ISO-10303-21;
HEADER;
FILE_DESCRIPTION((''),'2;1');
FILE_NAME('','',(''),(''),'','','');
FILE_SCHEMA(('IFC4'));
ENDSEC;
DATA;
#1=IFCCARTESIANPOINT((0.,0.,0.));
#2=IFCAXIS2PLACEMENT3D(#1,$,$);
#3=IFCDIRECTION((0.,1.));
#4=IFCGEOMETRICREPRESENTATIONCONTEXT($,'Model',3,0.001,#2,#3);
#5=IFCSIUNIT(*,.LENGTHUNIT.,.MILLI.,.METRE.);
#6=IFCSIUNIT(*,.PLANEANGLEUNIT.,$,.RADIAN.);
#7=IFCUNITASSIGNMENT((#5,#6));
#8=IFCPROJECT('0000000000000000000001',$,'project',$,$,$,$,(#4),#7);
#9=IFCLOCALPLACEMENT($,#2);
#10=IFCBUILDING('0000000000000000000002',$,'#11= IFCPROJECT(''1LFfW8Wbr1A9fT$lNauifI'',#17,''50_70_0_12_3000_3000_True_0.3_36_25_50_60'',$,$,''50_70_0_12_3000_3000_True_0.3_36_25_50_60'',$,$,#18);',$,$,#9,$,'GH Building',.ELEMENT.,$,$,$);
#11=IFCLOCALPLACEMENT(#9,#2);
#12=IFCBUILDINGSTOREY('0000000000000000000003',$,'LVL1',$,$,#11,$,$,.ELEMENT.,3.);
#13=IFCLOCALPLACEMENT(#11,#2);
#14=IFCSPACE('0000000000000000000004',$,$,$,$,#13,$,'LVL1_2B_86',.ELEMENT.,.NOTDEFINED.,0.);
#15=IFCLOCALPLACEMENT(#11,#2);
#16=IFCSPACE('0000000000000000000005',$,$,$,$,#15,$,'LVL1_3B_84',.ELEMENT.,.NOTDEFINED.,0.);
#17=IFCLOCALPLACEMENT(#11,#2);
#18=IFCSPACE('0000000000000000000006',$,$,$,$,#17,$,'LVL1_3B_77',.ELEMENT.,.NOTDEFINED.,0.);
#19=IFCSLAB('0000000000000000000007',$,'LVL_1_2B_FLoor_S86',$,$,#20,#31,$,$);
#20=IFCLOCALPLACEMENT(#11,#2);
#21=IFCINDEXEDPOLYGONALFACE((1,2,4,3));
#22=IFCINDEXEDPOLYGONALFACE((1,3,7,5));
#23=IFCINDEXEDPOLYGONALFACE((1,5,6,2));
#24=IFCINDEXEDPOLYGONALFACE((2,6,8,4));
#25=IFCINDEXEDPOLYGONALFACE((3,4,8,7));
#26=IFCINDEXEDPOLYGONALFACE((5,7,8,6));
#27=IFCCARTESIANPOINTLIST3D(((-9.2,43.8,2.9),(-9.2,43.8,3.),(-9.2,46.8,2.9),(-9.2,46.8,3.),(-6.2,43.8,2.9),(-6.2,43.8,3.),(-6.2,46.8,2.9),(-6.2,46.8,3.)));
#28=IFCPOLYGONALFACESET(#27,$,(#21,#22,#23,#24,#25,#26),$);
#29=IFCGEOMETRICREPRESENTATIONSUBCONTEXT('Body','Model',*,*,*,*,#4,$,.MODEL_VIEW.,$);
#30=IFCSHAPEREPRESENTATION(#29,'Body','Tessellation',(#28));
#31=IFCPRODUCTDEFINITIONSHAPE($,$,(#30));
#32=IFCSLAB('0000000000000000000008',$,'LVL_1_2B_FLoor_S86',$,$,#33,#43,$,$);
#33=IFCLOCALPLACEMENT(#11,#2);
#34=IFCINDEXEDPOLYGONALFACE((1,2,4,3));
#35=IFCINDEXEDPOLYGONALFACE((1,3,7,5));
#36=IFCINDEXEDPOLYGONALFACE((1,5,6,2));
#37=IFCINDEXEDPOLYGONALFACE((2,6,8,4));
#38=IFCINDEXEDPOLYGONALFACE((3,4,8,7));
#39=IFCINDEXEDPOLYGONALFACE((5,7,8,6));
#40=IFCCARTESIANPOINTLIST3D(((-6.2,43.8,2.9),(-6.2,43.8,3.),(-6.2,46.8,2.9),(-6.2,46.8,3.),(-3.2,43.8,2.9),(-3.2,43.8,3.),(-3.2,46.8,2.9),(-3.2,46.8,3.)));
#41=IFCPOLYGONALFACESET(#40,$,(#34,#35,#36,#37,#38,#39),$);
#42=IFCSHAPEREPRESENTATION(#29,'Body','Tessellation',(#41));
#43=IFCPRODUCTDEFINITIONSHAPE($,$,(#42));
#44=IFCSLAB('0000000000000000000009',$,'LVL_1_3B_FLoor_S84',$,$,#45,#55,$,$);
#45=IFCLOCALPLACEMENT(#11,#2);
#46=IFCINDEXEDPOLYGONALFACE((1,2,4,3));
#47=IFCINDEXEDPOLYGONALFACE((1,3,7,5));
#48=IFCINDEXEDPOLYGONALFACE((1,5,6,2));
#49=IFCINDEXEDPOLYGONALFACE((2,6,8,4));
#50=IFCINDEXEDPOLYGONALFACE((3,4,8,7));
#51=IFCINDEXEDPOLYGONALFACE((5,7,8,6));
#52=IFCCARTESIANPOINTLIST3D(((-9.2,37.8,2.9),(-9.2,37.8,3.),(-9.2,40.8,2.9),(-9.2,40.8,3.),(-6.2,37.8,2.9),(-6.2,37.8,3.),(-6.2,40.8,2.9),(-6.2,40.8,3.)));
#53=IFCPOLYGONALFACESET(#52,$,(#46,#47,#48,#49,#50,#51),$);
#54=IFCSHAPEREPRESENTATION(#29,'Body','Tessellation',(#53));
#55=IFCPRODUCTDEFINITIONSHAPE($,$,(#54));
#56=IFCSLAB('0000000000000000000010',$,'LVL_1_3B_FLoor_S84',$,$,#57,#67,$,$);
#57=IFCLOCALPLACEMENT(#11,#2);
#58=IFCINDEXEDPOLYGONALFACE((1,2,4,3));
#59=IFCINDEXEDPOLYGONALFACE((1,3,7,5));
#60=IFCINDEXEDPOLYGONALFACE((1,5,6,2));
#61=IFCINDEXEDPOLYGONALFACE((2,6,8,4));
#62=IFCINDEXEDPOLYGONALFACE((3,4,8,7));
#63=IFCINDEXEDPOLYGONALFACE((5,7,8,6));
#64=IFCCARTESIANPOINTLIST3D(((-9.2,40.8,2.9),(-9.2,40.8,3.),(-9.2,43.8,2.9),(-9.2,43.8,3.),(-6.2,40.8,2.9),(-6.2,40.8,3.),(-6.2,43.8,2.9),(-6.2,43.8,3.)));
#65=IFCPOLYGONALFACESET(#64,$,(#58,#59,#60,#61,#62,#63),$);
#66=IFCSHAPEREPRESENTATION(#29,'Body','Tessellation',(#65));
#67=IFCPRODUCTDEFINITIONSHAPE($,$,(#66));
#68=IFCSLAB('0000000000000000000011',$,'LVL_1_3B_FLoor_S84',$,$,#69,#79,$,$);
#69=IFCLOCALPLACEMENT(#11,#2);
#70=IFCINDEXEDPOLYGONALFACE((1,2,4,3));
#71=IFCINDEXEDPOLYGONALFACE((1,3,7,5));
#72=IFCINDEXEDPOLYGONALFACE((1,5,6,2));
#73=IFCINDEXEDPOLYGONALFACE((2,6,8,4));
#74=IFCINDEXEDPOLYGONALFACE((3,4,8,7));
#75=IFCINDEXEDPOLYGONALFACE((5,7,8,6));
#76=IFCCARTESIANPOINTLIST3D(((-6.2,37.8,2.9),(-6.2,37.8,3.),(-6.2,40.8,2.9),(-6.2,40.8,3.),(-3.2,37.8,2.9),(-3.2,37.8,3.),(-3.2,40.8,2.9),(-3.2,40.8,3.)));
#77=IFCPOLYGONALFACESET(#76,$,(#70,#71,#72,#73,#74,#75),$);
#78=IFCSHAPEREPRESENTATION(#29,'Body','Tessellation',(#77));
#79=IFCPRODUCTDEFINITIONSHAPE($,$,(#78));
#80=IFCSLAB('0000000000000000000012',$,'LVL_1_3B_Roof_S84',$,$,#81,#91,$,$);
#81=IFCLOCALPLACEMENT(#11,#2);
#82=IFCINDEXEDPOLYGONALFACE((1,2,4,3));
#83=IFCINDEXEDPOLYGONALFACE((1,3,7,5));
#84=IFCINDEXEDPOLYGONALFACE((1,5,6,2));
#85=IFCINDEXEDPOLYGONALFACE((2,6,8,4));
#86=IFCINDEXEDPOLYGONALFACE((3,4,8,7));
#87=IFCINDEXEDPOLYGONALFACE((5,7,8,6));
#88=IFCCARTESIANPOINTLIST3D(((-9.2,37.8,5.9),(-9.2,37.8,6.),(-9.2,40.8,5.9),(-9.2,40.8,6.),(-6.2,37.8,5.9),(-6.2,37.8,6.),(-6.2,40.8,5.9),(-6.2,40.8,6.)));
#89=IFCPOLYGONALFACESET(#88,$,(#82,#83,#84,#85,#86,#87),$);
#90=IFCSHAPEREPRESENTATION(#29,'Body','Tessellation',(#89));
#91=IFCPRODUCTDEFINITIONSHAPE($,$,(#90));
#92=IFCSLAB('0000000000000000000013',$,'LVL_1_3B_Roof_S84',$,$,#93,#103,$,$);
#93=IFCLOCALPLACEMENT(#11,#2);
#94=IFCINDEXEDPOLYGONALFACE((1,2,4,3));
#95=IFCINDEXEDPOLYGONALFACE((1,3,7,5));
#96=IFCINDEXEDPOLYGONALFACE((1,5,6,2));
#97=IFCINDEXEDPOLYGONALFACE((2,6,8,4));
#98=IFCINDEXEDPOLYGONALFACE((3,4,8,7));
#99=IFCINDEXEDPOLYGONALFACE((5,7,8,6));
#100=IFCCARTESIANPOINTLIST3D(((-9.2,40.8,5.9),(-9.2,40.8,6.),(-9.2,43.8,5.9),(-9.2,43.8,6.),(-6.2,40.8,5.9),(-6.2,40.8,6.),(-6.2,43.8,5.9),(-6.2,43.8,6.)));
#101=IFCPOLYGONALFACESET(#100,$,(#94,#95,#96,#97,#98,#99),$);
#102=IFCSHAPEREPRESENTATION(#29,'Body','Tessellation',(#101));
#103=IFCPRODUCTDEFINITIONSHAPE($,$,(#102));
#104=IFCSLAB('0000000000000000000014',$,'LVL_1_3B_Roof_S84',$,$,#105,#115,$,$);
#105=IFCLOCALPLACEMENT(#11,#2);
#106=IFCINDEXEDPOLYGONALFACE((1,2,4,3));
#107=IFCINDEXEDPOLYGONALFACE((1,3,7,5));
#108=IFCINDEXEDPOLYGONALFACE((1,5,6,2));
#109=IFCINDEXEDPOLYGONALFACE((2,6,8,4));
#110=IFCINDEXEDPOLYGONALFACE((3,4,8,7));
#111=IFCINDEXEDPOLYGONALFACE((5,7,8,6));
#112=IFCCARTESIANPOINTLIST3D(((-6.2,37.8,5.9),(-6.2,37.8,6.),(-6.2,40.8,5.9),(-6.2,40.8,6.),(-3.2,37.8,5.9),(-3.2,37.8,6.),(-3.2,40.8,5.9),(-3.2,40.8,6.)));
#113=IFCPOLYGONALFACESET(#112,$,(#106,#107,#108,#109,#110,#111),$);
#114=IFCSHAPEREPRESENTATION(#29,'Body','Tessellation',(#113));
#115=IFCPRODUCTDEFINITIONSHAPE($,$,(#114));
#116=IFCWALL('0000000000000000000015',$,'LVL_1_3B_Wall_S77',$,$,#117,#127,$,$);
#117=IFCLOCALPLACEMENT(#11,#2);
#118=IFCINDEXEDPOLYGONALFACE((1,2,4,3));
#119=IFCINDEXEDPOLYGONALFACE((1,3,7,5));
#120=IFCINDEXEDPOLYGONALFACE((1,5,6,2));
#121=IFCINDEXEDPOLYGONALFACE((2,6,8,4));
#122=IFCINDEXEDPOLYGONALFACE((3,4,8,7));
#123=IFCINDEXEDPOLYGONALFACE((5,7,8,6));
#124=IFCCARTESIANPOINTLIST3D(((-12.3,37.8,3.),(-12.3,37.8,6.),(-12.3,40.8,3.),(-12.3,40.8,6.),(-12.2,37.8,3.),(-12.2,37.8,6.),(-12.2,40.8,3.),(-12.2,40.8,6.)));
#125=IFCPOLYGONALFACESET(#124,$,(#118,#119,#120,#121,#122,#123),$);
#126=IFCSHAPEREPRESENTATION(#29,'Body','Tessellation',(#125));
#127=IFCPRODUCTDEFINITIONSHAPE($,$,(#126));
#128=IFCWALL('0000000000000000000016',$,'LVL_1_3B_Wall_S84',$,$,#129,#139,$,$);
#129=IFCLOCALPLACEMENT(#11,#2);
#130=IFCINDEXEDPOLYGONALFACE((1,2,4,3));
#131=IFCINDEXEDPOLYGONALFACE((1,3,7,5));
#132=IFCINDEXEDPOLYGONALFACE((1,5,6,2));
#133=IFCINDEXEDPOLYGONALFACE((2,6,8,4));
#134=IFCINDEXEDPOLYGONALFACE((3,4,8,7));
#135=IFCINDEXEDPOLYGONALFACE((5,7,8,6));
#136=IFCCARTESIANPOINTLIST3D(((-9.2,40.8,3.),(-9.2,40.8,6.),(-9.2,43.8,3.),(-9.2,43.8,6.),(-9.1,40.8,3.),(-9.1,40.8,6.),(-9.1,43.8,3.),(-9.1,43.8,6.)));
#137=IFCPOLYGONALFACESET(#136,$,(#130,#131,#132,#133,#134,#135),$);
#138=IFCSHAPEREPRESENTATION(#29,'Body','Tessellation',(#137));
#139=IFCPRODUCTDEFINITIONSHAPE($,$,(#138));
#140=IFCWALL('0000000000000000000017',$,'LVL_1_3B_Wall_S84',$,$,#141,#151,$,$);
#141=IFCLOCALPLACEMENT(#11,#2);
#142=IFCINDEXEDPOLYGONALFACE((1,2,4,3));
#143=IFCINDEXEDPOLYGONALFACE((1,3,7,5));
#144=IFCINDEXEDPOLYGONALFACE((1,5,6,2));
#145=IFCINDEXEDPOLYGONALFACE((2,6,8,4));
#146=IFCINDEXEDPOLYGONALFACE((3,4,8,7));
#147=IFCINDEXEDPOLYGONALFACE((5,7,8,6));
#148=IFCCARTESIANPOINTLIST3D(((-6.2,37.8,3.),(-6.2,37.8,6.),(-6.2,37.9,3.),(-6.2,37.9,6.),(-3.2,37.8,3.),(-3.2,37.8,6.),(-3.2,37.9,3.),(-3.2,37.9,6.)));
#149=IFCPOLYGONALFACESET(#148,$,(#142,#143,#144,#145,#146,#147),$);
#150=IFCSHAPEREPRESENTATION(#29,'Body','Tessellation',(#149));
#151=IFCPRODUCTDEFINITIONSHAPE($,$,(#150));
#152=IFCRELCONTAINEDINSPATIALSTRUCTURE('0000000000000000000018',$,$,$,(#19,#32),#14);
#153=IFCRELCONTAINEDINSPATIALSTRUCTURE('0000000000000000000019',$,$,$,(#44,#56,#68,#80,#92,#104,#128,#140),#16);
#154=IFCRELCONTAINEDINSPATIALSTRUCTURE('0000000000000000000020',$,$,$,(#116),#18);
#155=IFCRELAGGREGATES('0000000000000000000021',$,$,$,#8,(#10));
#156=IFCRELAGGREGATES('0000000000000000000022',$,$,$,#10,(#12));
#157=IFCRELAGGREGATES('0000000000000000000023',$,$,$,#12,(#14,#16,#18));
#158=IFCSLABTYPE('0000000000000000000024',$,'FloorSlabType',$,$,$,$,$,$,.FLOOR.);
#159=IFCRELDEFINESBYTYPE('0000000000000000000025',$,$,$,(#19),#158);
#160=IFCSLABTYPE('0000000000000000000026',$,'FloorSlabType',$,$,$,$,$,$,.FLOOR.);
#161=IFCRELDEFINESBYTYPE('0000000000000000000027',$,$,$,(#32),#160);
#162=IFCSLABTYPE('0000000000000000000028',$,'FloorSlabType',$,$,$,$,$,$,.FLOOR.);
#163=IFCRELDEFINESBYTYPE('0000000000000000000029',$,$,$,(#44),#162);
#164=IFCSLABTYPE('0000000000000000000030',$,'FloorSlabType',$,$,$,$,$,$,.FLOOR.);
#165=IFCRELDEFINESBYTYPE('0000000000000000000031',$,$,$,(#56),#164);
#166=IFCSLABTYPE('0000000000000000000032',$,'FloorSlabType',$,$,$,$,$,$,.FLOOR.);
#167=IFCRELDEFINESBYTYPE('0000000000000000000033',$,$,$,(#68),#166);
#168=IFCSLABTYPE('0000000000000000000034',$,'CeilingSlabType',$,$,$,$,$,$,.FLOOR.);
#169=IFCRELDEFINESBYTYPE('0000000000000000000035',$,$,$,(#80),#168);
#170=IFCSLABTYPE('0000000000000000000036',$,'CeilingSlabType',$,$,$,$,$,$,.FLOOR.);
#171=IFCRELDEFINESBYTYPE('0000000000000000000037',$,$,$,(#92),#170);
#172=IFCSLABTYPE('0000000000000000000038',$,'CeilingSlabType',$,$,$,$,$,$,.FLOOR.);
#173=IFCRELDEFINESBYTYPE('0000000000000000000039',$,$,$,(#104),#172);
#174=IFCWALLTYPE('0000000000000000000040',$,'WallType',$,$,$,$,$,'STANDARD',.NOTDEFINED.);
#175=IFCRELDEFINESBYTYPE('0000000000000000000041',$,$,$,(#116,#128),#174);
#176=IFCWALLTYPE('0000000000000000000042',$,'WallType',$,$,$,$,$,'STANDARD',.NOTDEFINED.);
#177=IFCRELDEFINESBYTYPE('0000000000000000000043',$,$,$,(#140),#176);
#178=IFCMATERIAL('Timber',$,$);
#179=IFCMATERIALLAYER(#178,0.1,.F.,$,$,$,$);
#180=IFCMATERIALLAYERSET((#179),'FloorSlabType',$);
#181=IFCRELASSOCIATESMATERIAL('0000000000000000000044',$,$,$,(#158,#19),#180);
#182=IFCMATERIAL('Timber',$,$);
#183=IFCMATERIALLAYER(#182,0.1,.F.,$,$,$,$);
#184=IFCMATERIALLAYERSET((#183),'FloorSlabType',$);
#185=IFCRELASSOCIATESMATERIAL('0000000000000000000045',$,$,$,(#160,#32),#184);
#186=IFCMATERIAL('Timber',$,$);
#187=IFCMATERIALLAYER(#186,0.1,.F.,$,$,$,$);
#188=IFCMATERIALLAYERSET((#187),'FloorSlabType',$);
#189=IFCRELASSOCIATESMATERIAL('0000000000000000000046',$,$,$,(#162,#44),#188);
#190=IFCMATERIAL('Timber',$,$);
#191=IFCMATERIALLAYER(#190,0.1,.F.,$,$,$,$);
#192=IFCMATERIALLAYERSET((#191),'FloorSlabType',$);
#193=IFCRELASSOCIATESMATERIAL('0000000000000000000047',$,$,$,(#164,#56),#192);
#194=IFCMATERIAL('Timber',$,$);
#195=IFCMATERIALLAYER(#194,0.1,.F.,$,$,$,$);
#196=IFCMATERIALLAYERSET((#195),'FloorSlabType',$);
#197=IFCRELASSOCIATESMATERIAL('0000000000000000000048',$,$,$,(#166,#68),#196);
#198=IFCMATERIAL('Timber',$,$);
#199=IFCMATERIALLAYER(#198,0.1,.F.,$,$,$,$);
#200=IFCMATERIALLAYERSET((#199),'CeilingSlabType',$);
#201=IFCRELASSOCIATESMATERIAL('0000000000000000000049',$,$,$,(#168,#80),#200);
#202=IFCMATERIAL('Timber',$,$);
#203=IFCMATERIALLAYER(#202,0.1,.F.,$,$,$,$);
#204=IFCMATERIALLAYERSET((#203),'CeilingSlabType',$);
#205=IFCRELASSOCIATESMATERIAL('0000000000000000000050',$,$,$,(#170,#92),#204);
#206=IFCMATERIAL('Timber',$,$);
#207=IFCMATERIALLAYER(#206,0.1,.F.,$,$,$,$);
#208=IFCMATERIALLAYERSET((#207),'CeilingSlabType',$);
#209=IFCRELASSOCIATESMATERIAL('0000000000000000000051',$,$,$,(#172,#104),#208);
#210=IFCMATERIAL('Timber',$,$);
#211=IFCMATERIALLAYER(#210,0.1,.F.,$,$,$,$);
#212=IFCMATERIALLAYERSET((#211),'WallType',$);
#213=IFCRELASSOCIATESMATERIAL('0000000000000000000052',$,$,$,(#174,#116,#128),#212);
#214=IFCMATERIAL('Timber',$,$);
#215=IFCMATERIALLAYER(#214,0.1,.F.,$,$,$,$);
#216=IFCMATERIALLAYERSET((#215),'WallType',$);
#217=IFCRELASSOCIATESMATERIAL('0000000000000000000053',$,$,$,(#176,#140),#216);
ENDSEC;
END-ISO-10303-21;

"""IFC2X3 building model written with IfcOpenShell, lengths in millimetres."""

from ifc_helpers import new_model, si_unit, direction, frame, frame_2d, origin, place, context, subcontext, project, spatial, rectangle, extrude, material, layer, layer_set, layer_usage, type_object, element, save


model = new_model("IFC2X3")

# Units and contexts
model_context = context("Model", 3, precision=0.001, world=origin(), true_north=direction((0.0, 1.0)))
body_context = subcontext(model_context, "Body", "Model", "MODEL_VIEW")
ifc_project = project(units=[si_unit("LENGTHUNIT", "METRE", prefix="MILLI"), si_unit("PLANEANGLEUNIT", "RADIAN")], contexts=[model_context])

# Building, storey
building_placement = place(None, origin())
building = spatial("IfcBuilding", under=ifc_project, at=building_placement, Name="#11= IFCPROJECT('1LFfW8Wbr1A9fT$lNauifI',#17,'50_70_0_12_3000_3000_True_0.3_36_25_50_60',$,$,'50_70_0_12_3000_3000_True_0.3_36_25_50_60',$,$,#18);", LongName="GH Building", CompositionType="ELEMENT")
storey_placement = place(building_placement, origin())
storey = spatial("IfcBuildingStorey", under=building, at=storey_placement, Name="LVL1", CompositionType="ELEMENT", Elevation=3.0)

# Shared definitions
space_1_placement = place(storey_placement, origin())
space_1 = spatial("IfcSpace", under=storey, at=space_1_placement, LongName="LVL1_2B_86", CompositionType="ELEMENT", InteriorOrExteriorSpace="NOTDEFINED", ElevationWithFlooring=0.0)

# Slabs
ifc_material_1 = material(Name="Timber")
ifc_layer_1 = layer(ifc_material_1, 0.1, ventilated=False)
ifc_layer_set_1 = layer_set([ifc_layer_1], Name="FloorSlabType")
ifc_layer_usage_1 = layer_usage(ifc_layer_set_1, "AXIS3", "NEGATIVE", -0.1)
slab_type_1 = type_object("IfcSlabType", Name="FloorSlabType", PredefinedType="FLOOR", material=ifc_layer_set_1)
slab_1_placement = place(space_1_placement, frame((-6.2, 43.8, 2.9), z_axis=(0.0, 0.0, 1.0), x_axis=(0.0, 1.0, 0.0)))
element("IfcSlab", 1, at=slab_1_placement, inside=space_1, type_object=slab_type_1, material=ifc_layer_usage_1, Name="LVL_1_2B_FLoor_S86", context=body_context, shape_type="SweptSolid", body=[
    extrude(rectangle(XDim=3.0, YDim=3.0, at=frame_2d((1.5, 1.5))), origin(), (0.0, 0.0, 1.0), 0.1),
])
ifc_material_2 = material(Name="Timber")
ifc_layer_2 = layer(ifc_material_2, 0.1, ventilated=False)
ifc_layer_set_2 = layer_set([ifc_layer_2], Name="FloorSlabType")
ifc_layer_usage_2 = layer_usage(ifc_layer_set_2, "AXIS3", "NEGATIVE", -0.1)
slab_type_2 = type_object("IfcSlabType", Name="FloorSlabType", PredefinedType="FLOOR", material=ifc_layer_set_2)
slab_2_placement = place(space_1_placement, frame((-3.2, 43.8, 2.9), z_axis=(0.0, 0.0, 1.0), x_axis=(0.0, 1.0, 0.0)))
element("IfcSlab", 2, at=slab_2_placement, inside=space_1, type_object=slab_type_2, material=ifc_layer_usage_2, Name="LVL_1_2B_FLoor_S86", context=body_context, shape_type="SweptSolid", body=[
    extrude(rectangle(XDim=3.0, YDim=3.0, at=frame_2d((1.5, 1.5))), origin(), (0.0, 0.0, 1.0), 0.1),
])

# Shared definitions
space_2_placement = place(storey_placement, origin())
space_2 = spatial("IfcSpace", under=storey, at=space_2_placement, LongName="LVL1_3B_84", CompositionType="ELEMENT", InteriorOrExteriorSpace="NOTDEFINED", ElevationWithFlooring=0.0)

# Slabs
ifc_material_3 = material(Name="Timber")
ifc_layer_3 = layer(ifc_material_3, 0.1, ventilated=False)
ifc_layer_set_3 = layer_set([ifc_layer_3], Name="FloorSlabType")
ifc_layer_usage_3 = layer_usage(ifc_layer_set_3, "AXIS3", "NEGATIVE", -0.1)
slab_type_3 = type_object("IfcSlabType", Name="FloorSlabType", PredefinedType="FLOOR", material=ifc_layer_set_3)
slab_3_placement = place(space_2_placement, frame((-6.2, 37.8, 2.9), z_axis=(0.0, 0.0, 1.0), x_axis=(0.0, 1.0, 0.0)))
element("IfcSlab", 3, at=slab_3_placement, inside=space_2, type_object=slab_type_3, material=ifc_layer_usage_3, Name="LVL_1_3B_FLoor_S84", context=body_context, shape_type="SweptSolid", body=[
    extrude(rectangle(XDim=3.0, YDim=3.0, at=frame_2d((1.5, 1.5))), origin(), (0.0, 0.0, 1.0), 0.1),
])
ifc_material_4 = material(Name="Timber")
ifc_layer_4 = layer(ifc_material_4, 0.1, ventilated=False)
ifc_layer_set_4 = layer_set([ifc_layer_4], Name="FloorSlabType")
ifc_layer_usage_4 = layer_usage(ifc_layer_set_4, "AXIS3", "NEGATIVE", -0.1)
slab_type_4 = type_object("IfcSlabType", Name="FloorSlabType", PredefinedType="FLOOR", material=ifc_layer_set_4)
slab_4_placement = place(space_2_placement, frame((-6.2, 40.8, 2.9), z_axis=(0.0, 0.0, 1.0), x_axis=(0.0, 1.0, 0.0)))
element("IfcSlab", 4, at=slab_4_placement, inside=space_2, type_object=slab_type_4, material=ifc_layer_usage_4, Name="LVL_1_3B_FLoor_S84", context=body_context, shape_type="SweptSolid", body=[
    extrude(rectangle(XDim=3.0, YDim=3.0, at=frame_2d((1.5, 1.5))), origin(), (0.0, 0.0, 1.0), 0.1),
])
ifc_material_5 = material(Name="Timber")
ifc_layer_5 = layer(ifc_material_5, 0.1, ventilated=False)
ifc_layer_set_5 = layer_set([ifc_layer_5], Name="FloorSlabType")
ifc_layer_usage_5 = layer_usage(ifc_layer_set_5, "AXIS3", "NEGATIVE", -0.1)
slab_type_5 = type_object("IfcSlabType", Name="FloorSlabType", PredefinedType="FLOOR", material=ifc_layer_set_5)
slab_5_placement = place(space_2_placement, frame((-3.2, 37.8, 2.9), z_axis=(0.0, 0.0, 1.0), x_axis=(0.0, 1.0, 0.0)))
element("IfcSlab", 5, at=slab_5_placement, inside=space_2, type_object=slab_type_5, material=ifc_layer_usage_5, Name="LVL_1_3B_FLoor_S84", context=body_context, shape_type="SweptSolid", body=[
    extrude(rectangle(XDim=3.0, YDim=3.0, at=frame_2d((1.5, 1.5))), origin(), (0.0, 0.0, 1.0), 0.1),
])
ifc_material_6 = material(Name="Timber")
ifc_layer_6 = layer(ifc_material_6, 0.1, ventilated=False)
ifc_layer_set_6 = layer_set([ifc_layer_6], Name="CeilingSlabType")
ifc_layer_usage_6 = layer_usage(ifc_layer_set_6, "AXIS3", "NEGATIVE", -0.1)
slab_type_6 = type_object("IfcSlabType", Name="CeilingSlabType", PredefinedType="FLOOR", material=ifc_layer_set_6)
slab_6_placement = place(space_2_placement, frame((-6.2, 37.8, 5.9), z_axis=(0.0, 0.0, 1.0), x_axis=(0.0, 1.0, 0.0)))
element("IfcSlab", 6, at=slab_6_placement, inside=space_2, type_object=slab_type_6, material=ifc_layer_usage_6, Name="LVL_1_3B_Roof_S84", context=body_context, shape_type="SweptSolid", body=[
    extrude(rectangle(XDim=3.0, YDim=3.0, at=frame_2d((1.5, 1.5))), origin(), (0.0, 0.0, 1.0), 0.1),
])
ifc_material_7 = material(Name="Timber")
ifc_layer_7 = layer(ifc_material_7, 0.1, ventilated=False)
ifc_layer_set_7 = layer_set([ifc_layer_7], Name="CeilingSlabType")
ifc_layer_usage_7 = layer_usage(ifc_layer_set_7, "AXIS3", "NEGATIVE", -0.1)
slab_type_7 = type_object("IfcSlabType", Name="CeilingSlabType", PredefinedType="FLOOR", material=ifc_layer_set_7)
slab_7_placement = place(space_2_placement, frame((-6.2, 40.8, 5.9), z_axis=(0.0, 0.0, 1.0), x_axis=(0.0, 1.0, 0.0)))
element("IfcSlab", 7, at=slab_7_placement, inside=space_2, type_object=slab_type_7, material=ifc_layer_usage_7, Name="LVL_1_3B_Roof_S84", context=body_context, shape_type="SweptSolid", body=[
    extrude(rectangle(XDim=3.0, YDim=3.0, at=frame_2d((1.5, 1.5))), origin(), (0.0, 0.0, 1.0), 0.1),
])
ifc_material_8 = material(Name="Timber")
ifc_layer_8 = layer(ifc_material_8, 0.1, ventilated=False)
ifc_layer_set_8 = layer_set([ifc_layer_8], Name="CeilingSlabType")
ifc_layer_usage_8 = layer_usage(ifc_layer_set_8, "AXIS3", "NEGATIVE", -0.1)
slab_type_8 = type_object("IfcSlabType", Name="CeilingSlabType", PredefinedType="FLOOR", material=ifc_layer_set_8)
slab_8_placement = place(space_2_placement, frame((-3.2, 37.8, 5.9), z_axis=(0.0, 0.0, 1.0), x_axis=(0.0, 1.0, 0.0)))
element("IfcSlab", 8, at=slab_8_placement, inside=space_2, type_object=slab_type_8, material=ifc_layer_usage_8, Name="LVL_1_3B_Roof_S84", context=body_context, shape_type="SweptSolid", body=[
    extrude(rectangle(XDim=3.0, YDim=3.0, at=frame_2d((1.5, 1.5))), origin(), (0.0, 0.0, 1.0), 0.1),
])

# Shared definitions
space_3_placement = place(storey_placement, origin())
space_3 = spatial("IfcSpace", under=storey, at=space_3_placement, LongName="LVL1_3B_77", CompositionType="ELEMENT", InteriorOrExteriorSpace="NOTDEFINED", ElevationWithFlooring=0.0)

# Walls
ifc_material_9 = material(Name="Timber")
ifc_layer_9 = layer(ifc_material_9, 0.1, ventilated=False)
ifc_layer_set_9 = layer_set([ifc_layer_9], Name="WallType")
ifc_layer_usage_9 = layer_usage(ifc_layer_set_9, "AXIS2", "NEGATIVE", 0.0)
wall_type_1 = type_object("IfcWallType", Name="WallType", ElementType="STANDARD", PredefinedType="NOTDEFINED", material=ifc_layer_set_9)
wall_1_placement = place(space_3_placement, frame((-12.2, 40.8, 3.0), z_axis=(0.0, 0.0, 1.0), x_axis=(0.0, -1.0, 0.0)))
element("IfcWall", 9, at=wall_1_placement, inside=space_3, type_object=wall_type_1, material=ifc_layer_usage_9, Name="LVL_1_3B_Wall_S77", context=body_context, shape_type="SweptSolid", body=[
    extrude(rectangle(XDim=3.0, YDim=0.1, at=frame_2d((1.5, -0.1))), origin(), (0.0, 0.0, 1.0), 3.0),
])
ifc_layer_usage_10 = layer_usage(ifc_layer_set_9, "AXIS2", "NEGATIVE", 0.0)
wall_2_placement = place(space_2_placement, frame((-9.2, 40.8, 3.0), z_axis=(0.0, 0.0, 1.0), x_axis=(0.0, 1.0, 0.0)))
element("IfcWall", 10, at=wall_2_placement, inside=space_2, type_object=wall_type_1, material=ifc_layer_usage_10, Name="LVL_1_3B_Wall_S84", context=body_context, shape_type="SweptSolid", body=[
    extrude(rectangle(XDim=3.0, YDim=0.1, at=frame_2d((1.5, -0.1))), origin(), (0.0, 0.0, 1.0), 3.0),
])
ifc_material_10 = material(Name="Timber")
ifc_layer_10 = layer(ifc_material_10, 0.1, ventilated=False)
ifc_layer_set_10 = layer_set([ifc_layer_10], Name="WallType")
ifc_layer_usage_11 = layer_usage(ifc_layer_set_10, "AXIS2", "NEGATIVE", 0.0)
wall_type_2 = type_object("IfcWallType", Name="WallType", ElementType="STANDARD", PredefinedType="NOTDEFINED", material=ifc_layer_set_10)
wall_3_placement = place(space_2_placement, frame((-3.2, 37.8, 3.0), z_axis=(0.0, 0.0, 1.0), x_axis=(-1.0, 0.0, 0.0)))
element("IfcWall", 11, at=wall_3_placement, inside=space_2, type_object=wall_type_2, material=ifc_layer_usage_11, Name="LVL_1_3B_Wall_S84", context=body_context, shape_type="SweptSolid", body=[
    extrude(rectangle(XDim=3.0, YDim=0.1, at=frame_2d((1.5, -0.1))), origin(), (0.0, 0.0, 1.0), 3.0),
])

save(model, "model.ifc")
